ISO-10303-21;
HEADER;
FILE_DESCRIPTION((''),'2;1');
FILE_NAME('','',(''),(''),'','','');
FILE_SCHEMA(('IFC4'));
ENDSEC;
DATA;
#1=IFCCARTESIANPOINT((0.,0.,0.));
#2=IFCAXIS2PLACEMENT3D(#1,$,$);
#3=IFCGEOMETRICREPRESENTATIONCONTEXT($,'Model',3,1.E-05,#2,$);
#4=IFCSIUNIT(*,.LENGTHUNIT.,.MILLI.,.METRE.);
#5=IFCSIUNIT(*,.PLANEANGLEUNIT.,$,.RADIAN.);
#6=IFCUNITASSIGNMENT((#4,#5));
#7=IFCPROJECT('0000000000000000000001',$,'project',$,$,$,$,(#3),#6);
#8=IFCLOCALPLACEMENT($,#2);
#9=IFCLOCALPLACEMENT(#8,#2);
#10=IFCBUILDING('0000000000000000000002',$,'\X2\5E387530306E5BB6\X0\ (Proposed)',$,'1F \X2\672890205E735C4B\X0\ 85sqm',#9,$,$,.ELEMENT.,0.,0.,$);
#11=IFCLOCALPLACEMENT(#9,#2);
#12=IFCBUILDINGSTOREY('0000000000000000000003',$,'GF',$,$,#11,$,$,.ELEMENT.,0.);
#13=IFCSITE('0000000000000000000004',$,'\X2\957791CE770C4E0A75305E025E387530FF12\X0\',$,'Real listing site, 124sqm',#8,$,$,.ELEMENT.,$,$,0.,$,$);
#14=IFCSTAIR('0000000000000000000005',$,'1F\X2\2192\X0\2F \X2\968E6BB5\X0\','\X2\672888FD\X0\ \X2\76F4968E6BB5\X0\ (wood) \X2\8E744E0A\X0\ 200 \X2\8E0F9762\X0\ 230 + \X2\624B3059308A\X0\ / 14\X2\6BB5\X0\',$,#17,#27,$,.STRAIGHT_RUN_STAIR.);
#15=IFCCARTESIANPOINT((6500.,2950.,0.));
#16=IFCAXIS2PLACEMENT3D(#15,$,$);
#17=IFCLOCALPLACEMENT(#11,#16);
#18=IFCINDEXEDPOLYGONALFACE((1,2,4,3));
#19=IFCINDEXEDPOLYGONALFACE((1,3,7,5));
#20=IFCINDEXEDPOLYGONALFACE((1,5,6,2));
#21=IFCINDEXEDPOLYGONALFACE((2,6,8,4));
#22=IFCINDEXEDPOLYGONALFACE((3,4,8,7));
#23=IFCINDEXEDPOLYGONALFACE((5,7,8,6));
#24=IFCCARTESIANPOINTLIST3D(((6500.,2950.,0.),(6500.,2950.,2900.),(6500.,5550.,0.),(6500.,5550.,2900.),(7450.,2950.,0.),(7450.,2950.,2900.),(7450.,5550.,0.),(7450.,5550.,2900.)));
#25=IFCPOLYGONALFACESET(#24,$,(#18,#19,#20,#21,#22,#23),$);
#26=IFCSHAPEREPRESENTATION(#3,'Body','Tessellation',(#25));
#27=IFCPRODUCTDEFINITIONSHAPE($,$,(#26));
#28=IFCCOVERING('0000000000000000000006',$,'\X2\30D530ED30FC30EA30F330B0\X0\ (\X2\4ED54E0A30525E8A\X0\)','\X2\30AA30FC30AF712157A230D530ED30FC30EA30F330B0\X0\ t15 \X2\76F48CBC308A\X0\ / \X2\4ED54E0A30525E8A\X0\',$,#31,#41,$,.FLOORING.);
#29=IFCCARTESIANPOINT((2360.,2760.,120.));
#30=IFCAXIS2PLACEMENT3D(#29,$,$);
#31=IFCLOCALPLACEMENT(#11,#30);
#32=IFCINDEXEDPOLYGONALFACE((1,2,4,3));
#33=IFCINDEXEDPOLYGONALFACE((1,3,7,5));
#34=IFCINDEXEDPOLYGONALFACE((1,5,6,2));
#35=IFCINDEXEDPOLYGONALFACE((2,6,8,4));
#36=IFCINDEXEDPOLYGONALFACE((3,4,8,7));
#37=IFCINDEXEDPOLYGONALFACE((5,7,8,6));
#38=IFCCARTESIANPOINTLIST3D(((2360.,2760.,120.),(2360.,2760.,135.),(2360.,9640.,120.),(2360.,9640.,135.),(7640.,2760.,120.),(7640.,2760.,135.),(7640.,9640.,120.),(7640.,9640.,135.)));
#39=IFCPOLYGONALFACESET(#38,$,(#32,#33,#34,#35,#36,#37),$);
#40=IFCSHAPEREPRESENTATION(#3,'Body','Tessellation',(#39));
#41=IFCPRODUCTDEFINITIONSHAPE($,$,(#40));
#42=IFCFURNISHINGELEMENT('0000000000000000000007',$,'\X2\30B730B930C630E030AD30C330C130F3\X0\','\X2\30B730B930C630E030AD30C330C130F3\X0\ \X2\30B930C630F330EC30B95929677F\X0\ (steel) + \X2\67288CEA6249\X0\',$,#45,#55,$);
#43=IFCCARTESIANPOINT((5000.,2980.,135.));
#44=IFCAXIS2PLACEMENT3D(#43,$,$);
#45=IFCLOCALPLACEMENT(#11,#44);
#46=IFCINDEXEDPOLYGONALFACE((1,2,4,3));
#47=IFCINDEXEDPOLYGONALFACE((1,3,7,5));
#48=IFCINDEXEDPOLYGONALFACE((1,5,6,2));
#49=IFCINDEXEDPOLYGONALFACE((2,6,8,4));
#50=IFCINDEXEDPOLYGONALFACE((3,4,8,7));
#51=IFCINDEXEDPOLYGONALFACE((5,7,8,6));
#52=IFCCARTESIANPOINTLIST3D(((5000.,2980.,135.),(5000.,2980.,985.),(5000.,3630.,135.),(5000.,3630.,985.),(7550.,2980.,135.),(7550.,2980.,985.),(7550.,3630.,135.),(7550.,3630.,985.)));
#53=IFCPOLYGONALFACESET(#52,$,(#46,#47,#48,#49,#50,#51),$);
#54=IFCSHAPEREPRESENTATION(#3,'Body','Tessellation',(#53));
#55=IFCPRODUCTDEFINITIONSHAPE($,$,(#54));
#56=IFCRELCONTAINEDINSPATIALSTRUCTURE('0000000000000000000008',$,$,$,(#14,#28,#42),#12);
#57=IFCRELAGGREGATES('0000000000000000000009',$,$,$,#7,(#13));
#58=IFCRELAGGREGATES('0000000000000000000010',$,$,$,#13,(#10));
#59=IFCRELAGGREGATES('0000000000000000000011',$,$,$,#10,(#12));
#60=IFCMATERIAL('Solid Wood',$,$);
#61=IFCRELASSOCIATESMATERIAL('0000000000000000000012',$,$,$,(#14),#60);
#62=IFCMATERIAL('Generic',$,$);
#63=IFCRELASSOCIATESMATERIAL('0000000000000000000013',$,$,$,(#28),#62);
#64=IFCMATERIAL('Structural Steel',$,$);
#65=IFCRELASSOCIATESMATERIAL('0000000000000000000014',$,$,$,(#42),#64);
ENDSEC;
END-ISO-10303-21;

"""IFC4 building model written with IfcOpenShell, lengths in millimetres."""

from ifc_helpers import new_model, si_unit, frame, frame_2d, origin, place, context, project, spatial, rectangle, extrude, material, element, save


model = new_model("IFC4")

# Units and contexts
model_context = context("Model", 3, precision=1e-05, world=origin())
ifc_project = project(units=[si_unit("LENGTHUNIT", "METRE", prefix="MILLI"), si_unit("PLANEANGLEUNIT", "RADIAN")], contexts=[model_context])

# Site, building, storey
site_placement = place(None, origin())
site = spatial("IfcSite", under=ifc_project, at=site_placement, Name="長野県上田市常田２", ObjectType="Real listing site, 124sqm", CompositionType="ELEMENT", RefElevation=0.0)
building_placement = place(site_placement, origin())
building = spatial("IfcBuilding", under=site, at=building_placement, Name="常田の家 (Proposed)", ObjectType="1F 木造平屋 85sqm", CompositionType="ELEMENT", ElevationOfRefHeight=0.0, ElevationOfTerrain=0.0)
storey_placement = place(building_placement, origin())
storey = spatial("IfcBuildingStorey", under=building, at=storey_placement, Name="GF", CompositionType="ELEMENT", Elevation=0.0)

# Shared definitions
ifc_material_1 = material(Name="Solid Wood")
ifc_material_2 = material(Name="Generic")

# Stair
stair_placement = place(storey_placement, frame((6500.0, 2950.0, 0.0)))
element("IfcStair", 1, at=stair_placement, inside=storey, material=ifc_material_1, Name="1F→2F 階段", Description="木製 直階段 (wood) 蹴上 200 踏面 230 + 手すり / 14段", PredefinedType="STRAIGHT_RUN_STAIR", context=model_context, shape_type="SweptSolid", body=[
    extrude(rectangle(XDim=950.0, YDim=2600.0, at=frame_2d((475.0, 1300.0))), frame((6500.0, 2950.0, 0.0)), (0.0, 0.0, 1.0), 2900.0),
])

# Covering
covering_placement = place(storey_placement, frame((2360.0, 2760.0, 120.0)))
element("IfcCovering", 2, at=covering_placement, inside=storey, material=ifc_material_2, Name="フローリング (仕上げ床)", Description="オーク無垢フローリング t15 直貼り / 仕上げ床", PredefinedType="FLOORING", context=model_context, shape_type="SweptSolid", body=[
    extrude(rectangle(XDim=5280.0, YDim=6880.0, at=frame_2d((2640.0, 3440.0))), frame((2360.0, 2760.0, 120.0)), (0.0, 0.0, 1.0), 15.0),
])

# Furnishing element
ifc_material_3 = material(Name="Structural Steel")
furnishing_placement = place(storey_placement, frame((5000.0, 2980.0, 135.0)))
element("IfcFurnishingElement", 3, at=furnishing_placement, inside=storey, material=ifc_material_3, Name="システムキッチン", Description="システムキッチン ステンレス天板 (steel) + 木質扉", context=model_context, shape_type="SweptSolid", body=[
    extrude(rectangle(XDim=2550.0, YDim=650.0, at=frame_2d((1275.0, 325.0))), frame((5000.0, 2980.0, 135.0)), (0.0, 0.0, 1.0), 850.0),
])

save(model, "model.ifc")
